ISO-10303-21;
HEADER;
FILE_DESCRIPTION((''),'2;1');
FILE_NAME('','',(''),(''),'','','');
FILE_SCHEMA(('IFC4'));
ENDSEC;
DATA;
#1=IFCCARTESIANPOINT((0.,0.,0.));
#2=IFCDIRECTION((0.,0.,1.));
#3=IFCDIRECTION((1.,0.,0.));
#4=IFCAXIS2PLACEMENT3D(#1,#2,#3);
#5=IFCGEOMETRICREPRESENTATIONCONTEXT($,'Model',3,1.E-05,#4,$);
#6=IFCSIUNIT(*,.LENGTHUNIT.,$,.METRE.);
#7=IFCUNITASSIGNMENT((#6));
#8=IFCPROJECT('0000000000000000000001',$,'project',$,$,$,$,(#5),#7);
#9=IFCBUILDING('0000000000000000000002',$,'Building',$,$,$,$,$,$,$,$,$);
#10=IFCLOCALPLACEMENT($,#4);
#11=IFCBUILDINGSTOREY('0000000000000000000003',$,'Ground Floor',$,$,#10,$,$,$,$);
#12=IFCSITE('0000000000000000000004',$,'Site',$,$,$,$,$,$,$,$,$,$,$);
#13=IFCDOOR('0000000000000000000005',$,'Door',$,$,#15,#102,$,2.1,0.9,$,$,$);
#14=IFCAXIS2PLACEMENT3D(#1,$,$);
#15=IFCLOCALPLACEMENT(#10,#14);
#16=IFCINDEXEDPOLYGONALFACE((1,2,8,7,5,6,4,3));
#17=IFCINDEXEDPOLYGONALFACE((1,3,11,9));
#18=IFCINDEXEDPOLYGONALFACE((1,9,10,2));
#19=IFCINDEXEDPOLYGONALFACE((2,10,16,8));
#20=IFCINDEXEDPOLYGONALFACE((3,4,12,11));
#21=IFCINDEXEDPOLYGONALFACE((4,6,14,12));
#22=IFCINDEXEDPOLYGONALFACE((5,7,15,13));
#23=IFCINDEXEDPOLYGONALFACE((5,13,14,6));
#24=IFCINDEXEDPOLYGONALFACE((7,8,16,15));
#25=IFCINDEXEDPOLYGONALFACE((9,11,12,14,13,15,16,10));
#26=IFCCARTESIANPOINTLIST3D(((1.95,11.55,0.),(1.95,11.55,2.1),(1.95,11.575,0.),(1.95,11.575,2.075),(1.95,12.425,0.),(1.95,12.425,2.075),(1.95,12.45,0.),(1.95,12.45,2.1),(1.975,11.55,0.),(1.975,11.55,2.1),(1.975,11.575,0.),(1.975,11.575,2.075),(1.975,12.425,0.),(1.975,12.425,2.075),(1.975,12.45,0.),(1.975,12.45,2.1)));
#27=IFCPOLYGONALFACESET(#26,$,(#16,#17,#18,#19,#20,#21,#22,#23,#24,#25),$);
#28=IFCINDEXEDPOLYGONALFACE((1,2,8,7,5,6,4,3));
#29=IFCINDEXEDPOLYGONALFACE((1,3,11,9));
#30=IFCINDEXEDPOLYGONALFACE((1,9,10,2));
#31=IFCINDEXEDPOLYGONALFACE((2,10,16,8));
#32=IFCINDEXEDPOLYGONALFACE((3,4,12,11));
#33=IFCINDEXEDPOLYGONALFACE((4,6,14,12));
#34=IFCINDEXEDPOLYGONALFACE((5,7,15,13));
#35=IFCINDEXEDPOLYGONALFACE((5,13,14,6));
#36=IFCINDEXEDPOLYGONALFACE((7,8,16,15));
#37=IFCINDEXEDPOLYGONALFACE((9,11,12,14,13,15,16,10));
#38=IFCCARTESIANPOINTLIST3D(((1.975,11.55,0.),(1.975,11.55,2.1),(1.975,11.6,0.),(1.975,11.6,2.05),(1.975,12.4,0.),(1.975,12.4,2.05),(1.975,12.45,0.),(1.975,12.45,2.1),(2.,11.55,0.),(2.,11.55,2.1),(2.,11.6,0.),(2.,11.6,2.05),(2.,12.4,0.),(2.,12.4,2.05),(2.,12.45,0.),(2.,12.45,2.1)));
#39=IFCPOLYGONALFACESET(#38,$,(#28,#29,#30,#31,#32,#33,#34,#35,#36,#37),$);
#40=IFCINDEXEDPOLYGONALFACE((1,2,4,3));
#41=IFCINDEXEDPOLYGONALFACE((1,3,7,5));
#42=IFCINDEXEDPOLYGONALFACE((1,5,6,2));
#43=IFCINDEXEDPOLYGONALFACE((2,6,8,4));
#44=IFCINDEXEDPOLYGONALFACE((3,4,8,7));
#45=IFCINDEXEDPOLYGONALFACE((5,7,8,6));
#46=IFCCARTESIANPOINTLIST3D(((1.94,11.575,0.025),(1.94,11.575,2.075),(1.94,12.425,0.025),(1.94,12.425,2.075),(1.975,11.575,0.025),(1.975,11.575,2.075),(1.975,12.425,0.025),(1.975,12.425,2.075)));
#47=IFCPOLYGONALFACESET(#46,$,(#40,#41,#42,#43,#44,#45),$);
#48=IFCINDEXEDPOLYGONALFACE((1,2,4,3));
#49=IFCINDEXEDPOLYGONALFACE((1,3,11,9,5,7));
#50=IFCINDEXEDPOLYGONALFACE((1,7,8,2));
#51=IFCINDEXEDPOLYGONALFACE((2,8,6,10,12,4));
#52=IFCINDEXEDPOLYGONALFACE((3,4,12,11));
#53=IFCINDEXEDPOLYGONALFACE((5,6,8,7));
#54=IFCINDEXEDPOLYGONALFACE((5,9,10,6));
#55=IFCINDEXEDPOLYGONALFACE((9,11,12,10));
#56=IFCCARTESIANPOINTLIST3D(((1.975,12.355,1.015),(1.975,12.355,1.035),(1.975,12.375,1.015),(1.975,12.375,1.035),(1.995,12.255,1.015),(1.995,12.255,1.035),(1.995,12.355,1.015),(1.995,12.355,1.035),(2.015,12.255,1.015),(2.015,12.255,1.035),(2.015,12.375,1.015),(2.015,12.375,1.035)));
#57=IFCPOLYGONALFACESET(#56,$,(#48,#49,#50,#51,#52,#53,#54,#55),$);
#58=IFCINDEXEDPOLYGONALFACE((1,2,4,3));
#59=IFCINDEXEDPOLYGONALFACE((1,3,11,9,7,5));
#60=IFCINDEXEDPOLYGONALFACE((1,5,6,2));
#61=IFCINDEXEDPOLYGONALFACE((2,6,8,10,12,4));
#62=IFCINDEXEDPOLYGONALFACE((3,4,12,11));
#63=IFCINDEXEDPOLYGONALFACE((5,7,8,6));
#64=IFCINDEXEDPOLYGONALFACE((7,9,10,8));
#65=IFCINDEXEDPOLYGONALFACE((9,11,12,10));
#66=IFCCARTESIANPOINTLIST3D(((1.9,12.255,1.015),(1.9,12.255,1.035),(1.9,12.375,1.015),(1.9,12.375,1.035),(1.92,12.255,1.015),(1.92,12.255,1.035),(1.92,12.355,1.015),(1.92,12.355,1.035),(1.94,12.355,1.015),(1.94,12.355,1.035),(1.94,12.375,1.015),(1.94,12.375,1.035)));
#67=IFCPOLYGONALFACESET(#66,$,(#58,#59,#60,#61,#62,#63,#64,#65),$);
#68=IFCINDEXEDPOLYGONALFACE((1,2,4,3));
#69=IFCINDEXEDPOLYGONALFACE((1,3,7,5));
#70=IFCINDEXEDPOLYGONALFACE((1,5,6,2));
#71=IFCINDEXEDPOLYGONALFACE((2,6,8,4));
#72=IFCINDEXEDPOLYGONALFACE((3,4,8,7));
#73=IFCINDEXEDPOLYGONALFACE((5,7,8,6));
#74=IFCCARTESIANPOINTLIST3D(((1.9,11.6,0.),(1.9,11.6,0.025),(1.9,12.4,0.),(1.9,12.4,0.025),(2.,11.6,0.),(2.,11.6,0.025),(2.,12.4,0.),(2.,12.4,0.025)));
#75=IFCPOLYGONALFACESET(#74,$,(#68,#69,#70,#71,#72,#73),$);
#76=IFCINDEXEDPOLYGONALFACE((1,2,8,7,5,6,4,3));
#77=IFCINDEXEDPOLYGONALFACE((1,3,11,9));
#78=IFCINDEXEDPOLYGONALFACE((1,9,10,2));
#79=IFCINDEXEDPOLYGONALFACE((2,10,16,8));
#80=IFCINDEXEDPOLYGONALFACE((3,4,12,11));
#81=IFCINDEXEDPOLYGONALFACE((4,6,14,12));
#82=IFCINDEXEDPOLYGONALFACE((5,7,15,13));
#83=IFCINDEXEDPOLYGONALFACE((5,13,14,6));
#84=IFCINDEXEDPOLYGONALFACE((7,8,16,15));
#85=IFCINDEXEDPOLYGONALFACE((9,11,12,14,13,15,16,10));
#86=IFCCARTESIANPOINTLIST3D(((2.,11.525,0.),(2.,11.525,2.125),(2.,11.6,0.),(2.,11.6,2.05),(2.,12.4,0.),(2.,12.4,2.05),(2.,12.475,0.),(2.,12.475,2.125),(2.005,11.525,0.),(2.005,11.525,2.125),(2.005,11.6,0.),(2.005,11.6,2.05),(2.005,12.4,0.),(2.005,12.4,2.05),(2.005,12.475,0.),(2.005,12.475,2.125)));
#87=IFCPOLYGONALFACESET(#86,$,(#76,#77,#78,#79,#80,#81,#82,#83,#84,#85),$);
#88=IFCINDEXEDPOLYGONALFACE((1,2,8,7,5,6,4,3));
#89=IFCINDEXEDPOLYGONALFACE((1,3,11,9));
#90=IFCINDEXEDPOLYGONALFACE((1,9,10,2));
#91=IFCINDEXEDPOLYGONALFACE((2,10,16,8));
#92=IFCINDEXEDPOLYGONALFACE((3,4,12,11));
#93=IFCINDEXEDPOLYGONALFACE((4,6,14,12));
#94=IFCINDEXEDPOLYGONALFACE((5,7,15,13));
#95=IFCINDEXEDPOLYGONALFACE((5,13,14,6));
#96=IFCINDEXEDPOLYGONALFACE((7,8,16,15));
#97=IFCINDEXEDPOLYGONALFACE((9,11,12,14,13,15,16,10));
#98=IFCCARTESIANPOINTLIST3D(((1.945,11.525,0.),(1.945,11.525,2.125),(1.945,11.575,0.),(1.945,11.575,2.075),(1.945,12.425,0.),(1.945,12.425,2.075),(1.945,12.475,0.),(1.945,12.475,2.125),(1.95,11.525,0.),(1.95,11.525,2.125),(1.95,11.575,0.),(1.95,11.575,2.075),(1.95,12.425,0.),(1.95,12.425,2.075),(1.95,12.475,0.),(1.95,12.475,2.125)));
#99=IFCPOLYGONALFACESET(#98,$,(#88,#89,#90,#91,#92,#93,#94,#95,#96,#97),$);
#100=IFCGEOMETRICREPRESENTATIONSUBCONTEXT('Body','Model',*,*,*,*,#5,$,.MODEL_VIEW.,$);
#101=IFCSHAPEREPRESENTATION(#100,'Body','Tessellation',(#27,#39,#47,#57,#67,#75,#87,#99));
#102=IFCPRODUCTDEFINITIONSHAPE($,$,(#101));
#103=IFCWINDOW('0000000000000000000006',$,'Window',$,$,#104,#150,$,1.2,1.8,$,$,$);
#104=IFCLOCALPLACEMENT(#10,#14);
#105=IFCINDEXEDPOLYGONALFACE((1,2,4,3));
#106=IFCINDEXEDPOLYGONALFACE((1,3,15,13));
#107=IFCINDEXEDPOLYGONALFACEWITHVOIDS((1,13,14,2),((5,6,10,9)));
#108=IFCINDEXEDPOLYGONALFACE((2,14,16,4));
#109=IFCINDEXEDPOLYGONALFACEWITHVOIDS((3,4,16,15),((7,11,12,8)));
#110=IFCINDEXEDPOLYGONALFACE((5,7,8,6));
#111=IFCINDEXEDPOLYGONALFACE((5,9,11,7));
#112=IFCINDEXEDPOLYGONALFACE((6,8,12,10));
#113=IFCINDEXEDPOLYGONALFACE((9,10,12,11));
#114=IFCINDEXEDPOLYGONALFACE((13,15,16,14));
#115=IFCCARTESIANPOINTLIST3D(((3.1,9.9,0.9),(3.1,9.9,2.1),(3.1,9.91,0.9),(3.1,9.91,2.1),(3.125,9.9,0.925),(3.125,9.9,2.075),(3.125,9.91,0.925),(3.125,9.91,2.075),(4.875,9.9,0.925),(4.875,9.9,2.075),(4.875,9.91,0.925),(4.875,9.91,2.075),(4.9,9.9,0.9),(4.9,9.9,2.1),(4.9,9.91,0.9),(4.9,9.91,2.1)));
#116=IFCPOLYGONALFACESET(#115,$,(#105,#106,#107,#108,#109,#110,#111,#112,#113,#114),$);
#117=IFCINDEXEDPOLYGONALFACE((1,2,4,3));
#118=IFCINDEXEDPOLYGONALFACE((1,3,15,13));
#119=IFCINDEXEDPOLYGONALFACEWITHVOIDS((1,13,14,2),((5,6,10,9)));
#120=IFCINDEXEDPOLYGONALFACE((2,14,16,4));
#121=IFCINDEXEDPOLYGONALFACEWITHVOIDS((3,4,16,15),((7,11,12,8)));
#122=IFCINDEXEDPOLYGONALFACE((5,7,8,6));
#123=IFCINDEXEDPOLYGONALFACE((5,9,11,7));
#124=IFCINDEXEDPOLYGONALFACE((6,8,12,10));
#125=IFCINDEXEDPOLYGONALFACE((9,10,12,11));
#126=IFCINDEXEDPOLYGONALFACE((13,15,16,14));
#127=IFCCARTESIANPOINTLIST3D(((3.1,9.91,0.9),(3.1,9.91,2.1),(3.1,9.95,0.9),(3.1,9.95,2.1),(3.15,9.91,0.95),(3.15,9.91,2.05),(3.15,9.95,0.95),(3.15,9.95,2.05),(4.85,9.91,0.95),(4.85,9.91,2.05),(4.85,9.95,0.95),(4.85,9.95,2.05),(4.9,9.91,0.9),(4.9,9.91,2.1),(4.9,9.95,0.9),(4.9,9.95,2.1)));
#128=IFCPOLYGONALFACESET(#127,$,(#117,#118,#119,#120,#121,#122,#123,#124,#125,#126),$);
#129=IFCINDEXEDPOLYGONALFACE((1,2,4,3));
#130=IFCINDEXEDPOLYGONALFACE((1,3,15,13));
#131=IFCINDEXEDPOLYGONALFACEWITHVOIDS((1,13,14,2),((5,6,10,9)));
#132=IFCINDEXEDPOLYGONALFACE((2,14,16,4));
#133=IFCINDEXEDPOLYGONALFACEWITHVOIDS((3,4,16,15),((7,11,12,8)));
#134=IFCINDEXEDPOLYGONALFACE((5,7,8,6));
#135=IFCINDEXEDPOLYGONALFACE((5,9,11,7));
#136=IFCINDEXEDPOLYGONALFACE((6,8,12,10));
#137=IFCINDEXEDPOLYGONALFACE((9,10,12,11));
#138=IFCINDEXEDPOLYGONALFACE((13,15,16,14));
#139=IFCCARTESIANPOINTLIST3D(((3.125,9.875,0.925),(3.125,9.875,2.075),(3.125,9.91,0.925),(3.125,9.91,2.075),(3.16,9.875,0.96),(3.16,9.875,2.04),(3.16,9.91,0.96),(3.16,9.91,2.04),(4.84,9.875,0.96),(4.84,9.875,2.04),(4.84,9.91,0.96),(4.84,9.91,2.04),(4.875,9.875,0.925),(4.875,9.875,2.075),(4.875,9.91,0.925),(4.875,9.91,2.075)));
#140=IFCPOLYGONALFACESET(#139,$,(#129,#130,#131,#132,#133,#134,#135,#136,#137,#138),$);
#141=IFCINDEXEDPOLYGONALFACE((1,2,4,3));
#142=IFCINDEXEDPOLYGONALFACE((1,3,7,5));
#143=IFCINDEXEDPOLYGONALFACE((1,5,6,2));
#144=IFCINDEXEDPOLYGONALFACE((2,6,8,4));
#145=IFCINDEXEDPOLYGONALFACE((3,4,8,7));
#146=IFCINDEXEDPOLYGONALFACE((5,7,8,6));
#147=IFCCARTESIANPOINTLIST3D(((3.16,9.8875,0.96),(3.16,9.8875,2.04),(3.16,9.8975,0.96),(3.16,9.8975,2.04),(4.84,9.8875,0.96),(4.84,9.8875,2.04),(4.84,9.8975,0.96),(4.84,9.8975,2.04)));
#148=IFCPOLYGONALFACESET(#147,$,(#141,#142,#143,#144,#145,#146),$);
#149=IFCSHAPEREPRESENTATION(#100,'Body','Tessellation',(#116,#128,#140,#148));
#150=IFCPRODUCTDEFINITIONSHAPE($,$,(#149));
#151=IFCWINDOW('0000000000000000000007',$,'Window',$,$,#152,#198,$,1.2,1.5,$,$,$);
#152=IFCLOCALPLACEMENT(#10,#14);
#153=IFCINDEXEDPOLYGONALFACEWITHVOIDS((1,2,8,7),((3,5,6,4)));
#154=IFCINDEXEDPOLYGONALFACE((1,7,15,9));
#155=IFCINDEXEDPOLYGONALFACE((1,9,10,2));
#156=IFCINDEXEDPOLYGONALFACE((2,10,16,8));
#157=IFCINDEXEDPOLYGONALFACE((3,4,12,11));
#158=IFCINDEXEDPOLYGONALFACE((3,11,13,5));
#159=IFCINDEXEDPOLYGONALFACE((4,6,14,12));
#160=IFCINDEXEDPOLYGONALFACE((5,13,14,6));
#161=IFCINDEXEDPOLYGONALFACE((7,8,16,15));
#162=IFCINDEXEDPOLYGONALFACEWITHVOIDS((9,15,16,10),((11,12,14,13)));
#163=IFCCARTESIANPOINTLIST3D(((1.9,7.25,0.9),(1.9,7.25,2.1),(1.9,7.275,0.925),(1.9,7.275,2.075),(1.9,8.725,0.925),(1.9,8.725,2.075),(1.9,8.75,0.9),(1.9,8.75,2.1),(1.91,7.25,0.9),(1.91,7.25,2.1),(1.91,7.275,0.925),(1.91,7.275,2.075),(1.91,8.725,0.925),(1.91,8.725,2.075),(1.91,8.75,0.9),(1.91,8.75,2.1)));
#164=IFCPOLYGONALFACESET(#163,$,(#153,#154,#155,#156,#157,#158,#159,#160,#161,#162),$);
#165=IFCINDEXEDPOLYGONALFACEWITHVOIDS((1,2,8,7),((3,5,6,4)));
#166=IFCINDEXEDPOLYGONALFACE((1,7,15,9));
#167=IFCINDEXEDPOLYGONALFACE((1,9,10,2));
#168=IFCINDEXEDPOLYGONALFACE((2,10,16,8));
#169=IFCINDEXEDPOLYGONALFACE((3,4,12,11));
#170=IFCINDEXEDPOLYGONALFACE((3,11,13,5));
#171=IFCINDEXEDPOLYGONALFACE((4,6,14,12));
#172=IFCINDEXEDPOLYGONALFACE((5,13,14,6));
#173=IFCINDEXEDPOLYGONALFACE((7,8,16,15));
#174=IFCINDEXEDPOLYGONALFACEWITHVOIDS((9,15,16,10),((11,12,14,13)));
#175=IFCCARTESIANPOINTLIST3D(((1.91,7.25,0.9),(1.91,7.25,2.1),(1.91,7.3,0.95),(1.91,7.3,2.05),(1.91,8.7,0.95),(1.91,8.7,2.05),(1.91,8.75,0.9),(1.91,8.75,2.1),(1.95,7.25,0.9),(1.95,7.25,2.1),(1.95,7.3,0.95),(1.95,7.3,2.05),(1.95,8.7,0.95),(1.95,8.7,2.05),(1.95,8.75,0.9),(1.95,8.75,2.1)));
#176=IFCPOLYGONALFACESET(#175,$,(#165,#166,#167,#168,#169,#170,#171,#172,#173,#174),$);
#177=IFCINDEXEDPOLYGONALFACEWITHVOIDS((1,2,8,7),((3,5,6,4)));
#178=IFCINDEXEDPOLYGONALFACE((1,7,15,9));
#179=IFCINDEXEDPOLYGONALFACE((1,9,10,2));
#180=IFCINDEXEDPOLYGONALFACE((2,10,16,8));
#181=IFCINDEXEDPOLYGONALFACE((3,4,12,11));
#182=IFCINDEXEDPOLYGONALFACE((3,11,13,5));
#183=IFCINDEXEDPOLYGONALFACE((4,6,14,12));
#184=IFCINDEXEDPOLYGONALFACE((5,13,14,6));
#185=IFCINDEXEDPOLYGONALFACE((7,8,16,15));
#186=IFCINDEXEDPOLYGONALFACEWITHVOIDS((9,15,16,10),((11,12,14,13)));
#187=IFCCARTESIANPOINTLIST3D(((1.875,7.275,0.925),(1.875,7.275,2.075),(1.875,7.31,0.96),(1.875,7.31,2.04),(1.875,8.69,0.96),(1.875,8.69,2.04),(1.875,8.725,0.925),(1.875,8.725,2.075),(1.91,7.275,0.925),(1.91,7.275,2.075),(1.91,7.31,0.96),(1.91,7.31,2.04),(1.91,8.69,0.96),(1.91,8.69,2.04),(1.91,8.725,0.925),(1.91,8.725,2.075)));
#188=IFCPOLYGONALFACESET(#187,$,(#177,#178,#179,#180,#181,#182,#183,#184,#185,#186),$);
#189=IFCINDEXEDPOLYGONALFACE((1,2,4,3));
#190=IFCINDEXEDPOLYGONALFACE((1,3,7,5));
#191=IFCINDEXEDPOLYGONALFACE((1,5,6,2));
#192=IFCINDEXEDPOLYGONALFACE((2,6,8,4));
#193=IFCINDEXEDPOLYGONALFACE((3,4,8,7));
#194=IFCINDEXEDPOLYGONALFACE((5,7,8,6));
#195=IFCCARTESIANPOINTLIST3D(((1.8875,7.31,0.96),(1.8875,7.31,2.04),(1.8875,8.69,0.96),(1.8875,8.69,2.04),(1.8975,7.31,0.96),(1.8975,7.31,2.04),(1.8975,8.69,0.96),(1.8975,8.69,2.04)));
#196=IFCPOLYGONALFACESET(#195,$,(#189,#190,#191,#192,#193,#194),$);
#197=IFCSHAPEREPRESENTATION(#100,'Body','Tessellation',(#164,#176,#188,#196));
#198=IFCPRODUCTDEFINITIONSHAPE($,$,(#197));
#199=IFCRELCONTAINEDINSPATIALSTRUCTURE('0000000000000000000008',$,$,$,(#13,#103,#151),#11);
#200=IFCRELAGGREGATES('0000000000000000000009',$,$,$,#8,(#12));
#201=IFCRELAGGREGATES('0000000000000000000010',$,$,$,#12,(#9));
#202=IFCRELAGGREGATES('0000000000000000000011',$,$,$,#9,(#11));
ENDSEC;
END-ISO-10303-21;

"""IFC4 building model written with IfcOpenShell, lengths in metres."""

from ifc_helpers import new_model, si_unit, frame, origin_with_axes, place, context, subcontext, project, spatial, line, indexed_curve, outline, extrude, element, save


model = new_model("IFC4")

# Units and contexts
model_context = context("Model", 3, precision=1e-05, world=origin_with_axes())
body_context = subcontext(model_context, "Body", "Model", "MODEL_VIEW")
ifc_project = project(units=[si_unit("LENGTHUNIT", "METRE")], contexts=[model_context])

# Site, building, storey
site = spatial("IfcSite", under=ifc_project, Name="Site")
building = spatial("IfcBuilding", under=site, Name="Building")
storey_placement = place(None, origin_with_axes())
storey = spatial("IfcBuildingStorey", under=building, at=storey_placement, Name="Ground Floor")

# Door
door_1_placement = place(storey_placement, frame((2.0, 11.55, 0.0), z_axis=(0.0, 0.0, 1.0), x_axis=(0.0, 1.0, 0.0)))
element("IfcDoor", 1, at=door_1_placement, inside=storey, Name="Door", OverallHeight=2.1, OverallWidth=0.9, context=body_context, shape_type="SweptSolid", body=[
    extrude(outline(indexed_curve([(0.0, 0.0), (0.0, 2.1), (0.9, 2.1), (0.9, 0.0), (0.875, 0.0), (0.875, 2.075), (0.025, 2.075), (0.025, 0.0)], segments=[line(1, 2, 3, 4, 5, 6, 7, 8, 1)])), frame((0.0, 0.025, 0.0), z_axis=(0.0, -1.0, 0.0), x_axis=(1.0, 0.0, 0.0)), (0.0, 0.0, -1.0), 0.025),
    extrude(outline(indexed_curve([(0.0, 0.0), (0.0, 2.1), (0.9, 2.1), (0.9, 0.0), (0.85, 0.0), (0.85, 2.05), (0.05, 2.05), (0.05, 0.0)], segments=[line(1, 2, 3, 4, 5, 6, 7, 8, 1)])), frame((0.0, 0.0, 0.0), z_axis=(0.0, -1.0, 0.0), x_axis=(1.0, 0.0, 0.0)), (0.0, 0.0, -1.0), 0.025),
    extrude(outline(indexed_curve([(0.0, 0.0), (0.85, 0.0), (0.85, 0.035), (0.0, 0.035)], segments=[line(1, 2, 3, 4, 1)])), frame((0.025, 0.025, 0.025), z_axis=(0.0, 0.0, 1.0), x_axis=(1.0, 0.0, 0.0)), (0.0, 0.0, 1.0), 2.05),
    extrude(outline(indexed_curve([(0.0, 0.0), (0.0, -0.04), (-0.12, -0.04), (-0.12, -0.02), (-0.02, -0.02), (-0.02, 0.0)], segments=[line(1, 2, 3, 4, 5, 6, 1)])), frame((0.825, 0.025, 1.015), z_axis=(0.0, 0.0, 1.0), x_axis=(1.0, 0.0, 0.0)), (0.0, 0.0, 1.0), 0.02),
    extrude(outline(indexed_curve([(0.0, 0.0), (0.0, 0.04), (-0.12, 0.04), (-0.12, 0.02), (-0.02, 0.02), (-0.02, 0.0)], segments=[line(1, 2, 3, 4, 5, 6, 1)])), frame((0.825, 0.06, 1.015), z_axis=(0.0, 0.0, 1.0), x_axis=(1.0, 0.0, 0.0)), (0.0, 0.0, 1.0), 0.02),
    extrude(outline(indexed_curve([(0.0, 0.0), (0.8, 0.0), (0.8, 0.1), (0.0, 0.1)], segments=[line(1, 2, 3, 4, 1)])), frame((0.05, 0.0, 0.0), z_axis=(0.0, 0.0, 1.0), x_axis=(1.0, 0.0, 0.0)), (0.0, 0.0, 1.0), 0.025),
    extrude(outline(indexed_curve([(0.0, 0.0), (0.0, 2.125), (0.95, 2.125), (0.95, 0.0), (0.875, 0.0), (0.875, 2.05), (0.075, 2.05), (0.075, 0.0)], segments=[line(1, 2, 3, 4, 5, 6, 7, 8, 1)])), frame((-0.025, -0.005, 0.0), z_axis=(0.0, -1.0, 0.0), x_axis=(1.0, 0.0, 0.0)), (0.0, 0.0, -1.0), 0.005),
    extrude(outline(indexed_curve([(0.0, 0.0), (0.0, 2.125), (0.95, 2.125), (0.95, 0.0), (0.9, 0.0), (0.9, 2.075), (0.05, 2.075), (0.05, 0.0)], segments=[line(1, 2, 3, 4, 5, 6, 7, 8, 1)])), frame((-0.025, 0.05, 0.0), z_axis=(0.0, -1.0, 0.0), x_axis=(1.0, 0.0, 0.0)), (0.0, 0.0, -1.0), 0.005),
])

# Windows
window_1_placement = place(storey_placement, frame((4.9, 10.0, 0.9), z_axis=(0.0, 0.0, 1.0), x_axis=(-1.0, 0.0, 0.0)))
element("IfcWindow", 2, at=window_1_placement, inside=storey, Name="Window", OverallHeight=1.2, OverallWidth=1.8, context=body_context, shape_type="SweptSolid", body=[
    extrude(outline(indexed_curve([(0.0, 0.0), (1.8, 0.0), (1.8, 1.2), (0.0, 1.2)], segments=[line(1, 2, 3, 4, 1)]), holes=[indexed_curve([(0.025, 0.025), (1.775, 0.025), (1.775, 1.175), (0.025, 1.175)], segments=[line(1, 2, 3, 4, 1)])]), frame((0.0, 0.09, 0.0), z_axis=(0.0, -1.0, 0.0), x_axis=(1.0, 0.0, 0.0)), (0.0, 0.0, -1.0), 0.01),
    extrude(outline(indexed_curve([(0.0, 0.0), (1.8, 0.0), (1.8, 1.2), (0.0, 1.2)], segments=[line(1, 2, 3, 4, 1)]), holes=[indexed_curve([(0.05, 0.05), (1.75, 0.05), (1.75, 1.15), (0.05, 1.15)], segments=[line(1, 2, 3, 4, 1)])]), frame((0.0, 0.05, 0.0), z_axis=(0.0, -1.0, 0.0), x_axis=(1.0, 0.0, 0.0)), (0.0, 0.0, -1.0), 0.04),
    extrude(outline(indexed_curve([(0.0, 0.0), (1.75, 0.0), (1.75, 1.15), (0.0, 1.15)], segments=[line(1, 2, 3, 4, 1)]), holes=[indexed_curve([(0.035, 0.035), (1.715, 0.035), (1.715, 1.115), (0.035, 1.115)], segments=[line(1, 2, 3, 4, 1)])]), frame((0.025, 0.09, 0.025), z_axis=(0.0, -1.0, 0.0), x_axis=(1.0, 0.0, 0.0)), (0.0, 0.0, -1.0), 0.035),
    extrude(outline(indexed_curve([(0.035, 0.035), (1.715, 0.035), (1.715, 1.115), (0.035, 1.115)], segments=[line(1, 2, 3, 4, 1)])), frame((0.025, 0.1025, 0.025), z_axis=(0.0, -1.0, 0.0), x_axis=(1.0, 0.0, 0.0)), (0.0, 0.0, -1.0), 0.01),
])
for number, where, z_axis, x_axis, name in (
    (3, (2.0, 7.25, 0.9), (0.0, 0.0, 1.0), (0.0, 1.0, 0.0), "Window"),
):
    element("IfcWindow", number, at=place(storey_placement, frame(where, z_axis=z_axis, x_axis=x_axis)), inside=storey, Name=name, OverallHeight=1.2, OverallWidth=1.5, context=body_context, shape_type="SweptSolid", body=[
        extrude(outline(indexed_curve([(0.0, 0.0), (1.5, 0.0), (1.5, 1.2), (0.0, 1.2)], segments=[line(1, 2, 3, 4, 1)]), holes=[indexed_curve([(0.025, 0.025), (1.475, 0.025), (1.475, 1.175), (0.025, 1.175)], segments=[line(1, 2, 3, 4, 1)])]), frame((0.0, 0.09, 0.0), z_axis=(0.0, -1.0, 0.0), x_axis=(1.0, 0.0, 0.0)), (0.0, 0.0, -1.0), 0.01),
        extrude(outline(indexed_curve([(0.0, 0.0), (1.5, 0.0), (1.5, 1.2), (0.0, 1.2)], segments=[line(1, 2, 3, 4, 1)]), holes=[indexed_curve([(0.05, 0.05), (1.45, 0.05), (1.45, 1.15), (0.05, 1.15)], segments=[line(1, 2, 3, 4, 1)])]), frame((0.0, 0.05, 0.0), z_axis=(0.0, -1.0, 0.0), x_axis=(1.0, 0.0, 0.0)), (0.0, 0.0, -1.0), 0.04),
        extrude(outline(indexed_curve([(0.0, 0.0), (1.45, 0.0), (1.45, 1.15), (0.0, 1.15)], segments=[line(1, 2, 3, 4, 1)]), holes=[indexed_curve([(0.035, 0.035), (1.415, 0.035), (1.415, 1.115), (0.035, 1.115)], segments=[line(1, 2, 3, 4, 1)])]), frame((0.025, 0.09, 0.025), z_axis=(0.0, -1.0, 0.0), x_axis=(1.0, 0.0, 0.0)), (0.0, 0.0, -1.0), 0.035),
        extrude(outline(indexed_curve([(0.035, 0.035), (1.415, 0.035), (1.415, 1.115), (0.035, 1.115)], segments=[line(1, 2, 3, 4, 1)])), frame((0.025, 0.1025, 0.025), z_axis=(0.0, -1.0, 0.0), x_axis=(1.0, 0.0, 0.0)), (0.0, 0.0, -1.0), 0.01),
    ])

save(model, "model.ifc")
